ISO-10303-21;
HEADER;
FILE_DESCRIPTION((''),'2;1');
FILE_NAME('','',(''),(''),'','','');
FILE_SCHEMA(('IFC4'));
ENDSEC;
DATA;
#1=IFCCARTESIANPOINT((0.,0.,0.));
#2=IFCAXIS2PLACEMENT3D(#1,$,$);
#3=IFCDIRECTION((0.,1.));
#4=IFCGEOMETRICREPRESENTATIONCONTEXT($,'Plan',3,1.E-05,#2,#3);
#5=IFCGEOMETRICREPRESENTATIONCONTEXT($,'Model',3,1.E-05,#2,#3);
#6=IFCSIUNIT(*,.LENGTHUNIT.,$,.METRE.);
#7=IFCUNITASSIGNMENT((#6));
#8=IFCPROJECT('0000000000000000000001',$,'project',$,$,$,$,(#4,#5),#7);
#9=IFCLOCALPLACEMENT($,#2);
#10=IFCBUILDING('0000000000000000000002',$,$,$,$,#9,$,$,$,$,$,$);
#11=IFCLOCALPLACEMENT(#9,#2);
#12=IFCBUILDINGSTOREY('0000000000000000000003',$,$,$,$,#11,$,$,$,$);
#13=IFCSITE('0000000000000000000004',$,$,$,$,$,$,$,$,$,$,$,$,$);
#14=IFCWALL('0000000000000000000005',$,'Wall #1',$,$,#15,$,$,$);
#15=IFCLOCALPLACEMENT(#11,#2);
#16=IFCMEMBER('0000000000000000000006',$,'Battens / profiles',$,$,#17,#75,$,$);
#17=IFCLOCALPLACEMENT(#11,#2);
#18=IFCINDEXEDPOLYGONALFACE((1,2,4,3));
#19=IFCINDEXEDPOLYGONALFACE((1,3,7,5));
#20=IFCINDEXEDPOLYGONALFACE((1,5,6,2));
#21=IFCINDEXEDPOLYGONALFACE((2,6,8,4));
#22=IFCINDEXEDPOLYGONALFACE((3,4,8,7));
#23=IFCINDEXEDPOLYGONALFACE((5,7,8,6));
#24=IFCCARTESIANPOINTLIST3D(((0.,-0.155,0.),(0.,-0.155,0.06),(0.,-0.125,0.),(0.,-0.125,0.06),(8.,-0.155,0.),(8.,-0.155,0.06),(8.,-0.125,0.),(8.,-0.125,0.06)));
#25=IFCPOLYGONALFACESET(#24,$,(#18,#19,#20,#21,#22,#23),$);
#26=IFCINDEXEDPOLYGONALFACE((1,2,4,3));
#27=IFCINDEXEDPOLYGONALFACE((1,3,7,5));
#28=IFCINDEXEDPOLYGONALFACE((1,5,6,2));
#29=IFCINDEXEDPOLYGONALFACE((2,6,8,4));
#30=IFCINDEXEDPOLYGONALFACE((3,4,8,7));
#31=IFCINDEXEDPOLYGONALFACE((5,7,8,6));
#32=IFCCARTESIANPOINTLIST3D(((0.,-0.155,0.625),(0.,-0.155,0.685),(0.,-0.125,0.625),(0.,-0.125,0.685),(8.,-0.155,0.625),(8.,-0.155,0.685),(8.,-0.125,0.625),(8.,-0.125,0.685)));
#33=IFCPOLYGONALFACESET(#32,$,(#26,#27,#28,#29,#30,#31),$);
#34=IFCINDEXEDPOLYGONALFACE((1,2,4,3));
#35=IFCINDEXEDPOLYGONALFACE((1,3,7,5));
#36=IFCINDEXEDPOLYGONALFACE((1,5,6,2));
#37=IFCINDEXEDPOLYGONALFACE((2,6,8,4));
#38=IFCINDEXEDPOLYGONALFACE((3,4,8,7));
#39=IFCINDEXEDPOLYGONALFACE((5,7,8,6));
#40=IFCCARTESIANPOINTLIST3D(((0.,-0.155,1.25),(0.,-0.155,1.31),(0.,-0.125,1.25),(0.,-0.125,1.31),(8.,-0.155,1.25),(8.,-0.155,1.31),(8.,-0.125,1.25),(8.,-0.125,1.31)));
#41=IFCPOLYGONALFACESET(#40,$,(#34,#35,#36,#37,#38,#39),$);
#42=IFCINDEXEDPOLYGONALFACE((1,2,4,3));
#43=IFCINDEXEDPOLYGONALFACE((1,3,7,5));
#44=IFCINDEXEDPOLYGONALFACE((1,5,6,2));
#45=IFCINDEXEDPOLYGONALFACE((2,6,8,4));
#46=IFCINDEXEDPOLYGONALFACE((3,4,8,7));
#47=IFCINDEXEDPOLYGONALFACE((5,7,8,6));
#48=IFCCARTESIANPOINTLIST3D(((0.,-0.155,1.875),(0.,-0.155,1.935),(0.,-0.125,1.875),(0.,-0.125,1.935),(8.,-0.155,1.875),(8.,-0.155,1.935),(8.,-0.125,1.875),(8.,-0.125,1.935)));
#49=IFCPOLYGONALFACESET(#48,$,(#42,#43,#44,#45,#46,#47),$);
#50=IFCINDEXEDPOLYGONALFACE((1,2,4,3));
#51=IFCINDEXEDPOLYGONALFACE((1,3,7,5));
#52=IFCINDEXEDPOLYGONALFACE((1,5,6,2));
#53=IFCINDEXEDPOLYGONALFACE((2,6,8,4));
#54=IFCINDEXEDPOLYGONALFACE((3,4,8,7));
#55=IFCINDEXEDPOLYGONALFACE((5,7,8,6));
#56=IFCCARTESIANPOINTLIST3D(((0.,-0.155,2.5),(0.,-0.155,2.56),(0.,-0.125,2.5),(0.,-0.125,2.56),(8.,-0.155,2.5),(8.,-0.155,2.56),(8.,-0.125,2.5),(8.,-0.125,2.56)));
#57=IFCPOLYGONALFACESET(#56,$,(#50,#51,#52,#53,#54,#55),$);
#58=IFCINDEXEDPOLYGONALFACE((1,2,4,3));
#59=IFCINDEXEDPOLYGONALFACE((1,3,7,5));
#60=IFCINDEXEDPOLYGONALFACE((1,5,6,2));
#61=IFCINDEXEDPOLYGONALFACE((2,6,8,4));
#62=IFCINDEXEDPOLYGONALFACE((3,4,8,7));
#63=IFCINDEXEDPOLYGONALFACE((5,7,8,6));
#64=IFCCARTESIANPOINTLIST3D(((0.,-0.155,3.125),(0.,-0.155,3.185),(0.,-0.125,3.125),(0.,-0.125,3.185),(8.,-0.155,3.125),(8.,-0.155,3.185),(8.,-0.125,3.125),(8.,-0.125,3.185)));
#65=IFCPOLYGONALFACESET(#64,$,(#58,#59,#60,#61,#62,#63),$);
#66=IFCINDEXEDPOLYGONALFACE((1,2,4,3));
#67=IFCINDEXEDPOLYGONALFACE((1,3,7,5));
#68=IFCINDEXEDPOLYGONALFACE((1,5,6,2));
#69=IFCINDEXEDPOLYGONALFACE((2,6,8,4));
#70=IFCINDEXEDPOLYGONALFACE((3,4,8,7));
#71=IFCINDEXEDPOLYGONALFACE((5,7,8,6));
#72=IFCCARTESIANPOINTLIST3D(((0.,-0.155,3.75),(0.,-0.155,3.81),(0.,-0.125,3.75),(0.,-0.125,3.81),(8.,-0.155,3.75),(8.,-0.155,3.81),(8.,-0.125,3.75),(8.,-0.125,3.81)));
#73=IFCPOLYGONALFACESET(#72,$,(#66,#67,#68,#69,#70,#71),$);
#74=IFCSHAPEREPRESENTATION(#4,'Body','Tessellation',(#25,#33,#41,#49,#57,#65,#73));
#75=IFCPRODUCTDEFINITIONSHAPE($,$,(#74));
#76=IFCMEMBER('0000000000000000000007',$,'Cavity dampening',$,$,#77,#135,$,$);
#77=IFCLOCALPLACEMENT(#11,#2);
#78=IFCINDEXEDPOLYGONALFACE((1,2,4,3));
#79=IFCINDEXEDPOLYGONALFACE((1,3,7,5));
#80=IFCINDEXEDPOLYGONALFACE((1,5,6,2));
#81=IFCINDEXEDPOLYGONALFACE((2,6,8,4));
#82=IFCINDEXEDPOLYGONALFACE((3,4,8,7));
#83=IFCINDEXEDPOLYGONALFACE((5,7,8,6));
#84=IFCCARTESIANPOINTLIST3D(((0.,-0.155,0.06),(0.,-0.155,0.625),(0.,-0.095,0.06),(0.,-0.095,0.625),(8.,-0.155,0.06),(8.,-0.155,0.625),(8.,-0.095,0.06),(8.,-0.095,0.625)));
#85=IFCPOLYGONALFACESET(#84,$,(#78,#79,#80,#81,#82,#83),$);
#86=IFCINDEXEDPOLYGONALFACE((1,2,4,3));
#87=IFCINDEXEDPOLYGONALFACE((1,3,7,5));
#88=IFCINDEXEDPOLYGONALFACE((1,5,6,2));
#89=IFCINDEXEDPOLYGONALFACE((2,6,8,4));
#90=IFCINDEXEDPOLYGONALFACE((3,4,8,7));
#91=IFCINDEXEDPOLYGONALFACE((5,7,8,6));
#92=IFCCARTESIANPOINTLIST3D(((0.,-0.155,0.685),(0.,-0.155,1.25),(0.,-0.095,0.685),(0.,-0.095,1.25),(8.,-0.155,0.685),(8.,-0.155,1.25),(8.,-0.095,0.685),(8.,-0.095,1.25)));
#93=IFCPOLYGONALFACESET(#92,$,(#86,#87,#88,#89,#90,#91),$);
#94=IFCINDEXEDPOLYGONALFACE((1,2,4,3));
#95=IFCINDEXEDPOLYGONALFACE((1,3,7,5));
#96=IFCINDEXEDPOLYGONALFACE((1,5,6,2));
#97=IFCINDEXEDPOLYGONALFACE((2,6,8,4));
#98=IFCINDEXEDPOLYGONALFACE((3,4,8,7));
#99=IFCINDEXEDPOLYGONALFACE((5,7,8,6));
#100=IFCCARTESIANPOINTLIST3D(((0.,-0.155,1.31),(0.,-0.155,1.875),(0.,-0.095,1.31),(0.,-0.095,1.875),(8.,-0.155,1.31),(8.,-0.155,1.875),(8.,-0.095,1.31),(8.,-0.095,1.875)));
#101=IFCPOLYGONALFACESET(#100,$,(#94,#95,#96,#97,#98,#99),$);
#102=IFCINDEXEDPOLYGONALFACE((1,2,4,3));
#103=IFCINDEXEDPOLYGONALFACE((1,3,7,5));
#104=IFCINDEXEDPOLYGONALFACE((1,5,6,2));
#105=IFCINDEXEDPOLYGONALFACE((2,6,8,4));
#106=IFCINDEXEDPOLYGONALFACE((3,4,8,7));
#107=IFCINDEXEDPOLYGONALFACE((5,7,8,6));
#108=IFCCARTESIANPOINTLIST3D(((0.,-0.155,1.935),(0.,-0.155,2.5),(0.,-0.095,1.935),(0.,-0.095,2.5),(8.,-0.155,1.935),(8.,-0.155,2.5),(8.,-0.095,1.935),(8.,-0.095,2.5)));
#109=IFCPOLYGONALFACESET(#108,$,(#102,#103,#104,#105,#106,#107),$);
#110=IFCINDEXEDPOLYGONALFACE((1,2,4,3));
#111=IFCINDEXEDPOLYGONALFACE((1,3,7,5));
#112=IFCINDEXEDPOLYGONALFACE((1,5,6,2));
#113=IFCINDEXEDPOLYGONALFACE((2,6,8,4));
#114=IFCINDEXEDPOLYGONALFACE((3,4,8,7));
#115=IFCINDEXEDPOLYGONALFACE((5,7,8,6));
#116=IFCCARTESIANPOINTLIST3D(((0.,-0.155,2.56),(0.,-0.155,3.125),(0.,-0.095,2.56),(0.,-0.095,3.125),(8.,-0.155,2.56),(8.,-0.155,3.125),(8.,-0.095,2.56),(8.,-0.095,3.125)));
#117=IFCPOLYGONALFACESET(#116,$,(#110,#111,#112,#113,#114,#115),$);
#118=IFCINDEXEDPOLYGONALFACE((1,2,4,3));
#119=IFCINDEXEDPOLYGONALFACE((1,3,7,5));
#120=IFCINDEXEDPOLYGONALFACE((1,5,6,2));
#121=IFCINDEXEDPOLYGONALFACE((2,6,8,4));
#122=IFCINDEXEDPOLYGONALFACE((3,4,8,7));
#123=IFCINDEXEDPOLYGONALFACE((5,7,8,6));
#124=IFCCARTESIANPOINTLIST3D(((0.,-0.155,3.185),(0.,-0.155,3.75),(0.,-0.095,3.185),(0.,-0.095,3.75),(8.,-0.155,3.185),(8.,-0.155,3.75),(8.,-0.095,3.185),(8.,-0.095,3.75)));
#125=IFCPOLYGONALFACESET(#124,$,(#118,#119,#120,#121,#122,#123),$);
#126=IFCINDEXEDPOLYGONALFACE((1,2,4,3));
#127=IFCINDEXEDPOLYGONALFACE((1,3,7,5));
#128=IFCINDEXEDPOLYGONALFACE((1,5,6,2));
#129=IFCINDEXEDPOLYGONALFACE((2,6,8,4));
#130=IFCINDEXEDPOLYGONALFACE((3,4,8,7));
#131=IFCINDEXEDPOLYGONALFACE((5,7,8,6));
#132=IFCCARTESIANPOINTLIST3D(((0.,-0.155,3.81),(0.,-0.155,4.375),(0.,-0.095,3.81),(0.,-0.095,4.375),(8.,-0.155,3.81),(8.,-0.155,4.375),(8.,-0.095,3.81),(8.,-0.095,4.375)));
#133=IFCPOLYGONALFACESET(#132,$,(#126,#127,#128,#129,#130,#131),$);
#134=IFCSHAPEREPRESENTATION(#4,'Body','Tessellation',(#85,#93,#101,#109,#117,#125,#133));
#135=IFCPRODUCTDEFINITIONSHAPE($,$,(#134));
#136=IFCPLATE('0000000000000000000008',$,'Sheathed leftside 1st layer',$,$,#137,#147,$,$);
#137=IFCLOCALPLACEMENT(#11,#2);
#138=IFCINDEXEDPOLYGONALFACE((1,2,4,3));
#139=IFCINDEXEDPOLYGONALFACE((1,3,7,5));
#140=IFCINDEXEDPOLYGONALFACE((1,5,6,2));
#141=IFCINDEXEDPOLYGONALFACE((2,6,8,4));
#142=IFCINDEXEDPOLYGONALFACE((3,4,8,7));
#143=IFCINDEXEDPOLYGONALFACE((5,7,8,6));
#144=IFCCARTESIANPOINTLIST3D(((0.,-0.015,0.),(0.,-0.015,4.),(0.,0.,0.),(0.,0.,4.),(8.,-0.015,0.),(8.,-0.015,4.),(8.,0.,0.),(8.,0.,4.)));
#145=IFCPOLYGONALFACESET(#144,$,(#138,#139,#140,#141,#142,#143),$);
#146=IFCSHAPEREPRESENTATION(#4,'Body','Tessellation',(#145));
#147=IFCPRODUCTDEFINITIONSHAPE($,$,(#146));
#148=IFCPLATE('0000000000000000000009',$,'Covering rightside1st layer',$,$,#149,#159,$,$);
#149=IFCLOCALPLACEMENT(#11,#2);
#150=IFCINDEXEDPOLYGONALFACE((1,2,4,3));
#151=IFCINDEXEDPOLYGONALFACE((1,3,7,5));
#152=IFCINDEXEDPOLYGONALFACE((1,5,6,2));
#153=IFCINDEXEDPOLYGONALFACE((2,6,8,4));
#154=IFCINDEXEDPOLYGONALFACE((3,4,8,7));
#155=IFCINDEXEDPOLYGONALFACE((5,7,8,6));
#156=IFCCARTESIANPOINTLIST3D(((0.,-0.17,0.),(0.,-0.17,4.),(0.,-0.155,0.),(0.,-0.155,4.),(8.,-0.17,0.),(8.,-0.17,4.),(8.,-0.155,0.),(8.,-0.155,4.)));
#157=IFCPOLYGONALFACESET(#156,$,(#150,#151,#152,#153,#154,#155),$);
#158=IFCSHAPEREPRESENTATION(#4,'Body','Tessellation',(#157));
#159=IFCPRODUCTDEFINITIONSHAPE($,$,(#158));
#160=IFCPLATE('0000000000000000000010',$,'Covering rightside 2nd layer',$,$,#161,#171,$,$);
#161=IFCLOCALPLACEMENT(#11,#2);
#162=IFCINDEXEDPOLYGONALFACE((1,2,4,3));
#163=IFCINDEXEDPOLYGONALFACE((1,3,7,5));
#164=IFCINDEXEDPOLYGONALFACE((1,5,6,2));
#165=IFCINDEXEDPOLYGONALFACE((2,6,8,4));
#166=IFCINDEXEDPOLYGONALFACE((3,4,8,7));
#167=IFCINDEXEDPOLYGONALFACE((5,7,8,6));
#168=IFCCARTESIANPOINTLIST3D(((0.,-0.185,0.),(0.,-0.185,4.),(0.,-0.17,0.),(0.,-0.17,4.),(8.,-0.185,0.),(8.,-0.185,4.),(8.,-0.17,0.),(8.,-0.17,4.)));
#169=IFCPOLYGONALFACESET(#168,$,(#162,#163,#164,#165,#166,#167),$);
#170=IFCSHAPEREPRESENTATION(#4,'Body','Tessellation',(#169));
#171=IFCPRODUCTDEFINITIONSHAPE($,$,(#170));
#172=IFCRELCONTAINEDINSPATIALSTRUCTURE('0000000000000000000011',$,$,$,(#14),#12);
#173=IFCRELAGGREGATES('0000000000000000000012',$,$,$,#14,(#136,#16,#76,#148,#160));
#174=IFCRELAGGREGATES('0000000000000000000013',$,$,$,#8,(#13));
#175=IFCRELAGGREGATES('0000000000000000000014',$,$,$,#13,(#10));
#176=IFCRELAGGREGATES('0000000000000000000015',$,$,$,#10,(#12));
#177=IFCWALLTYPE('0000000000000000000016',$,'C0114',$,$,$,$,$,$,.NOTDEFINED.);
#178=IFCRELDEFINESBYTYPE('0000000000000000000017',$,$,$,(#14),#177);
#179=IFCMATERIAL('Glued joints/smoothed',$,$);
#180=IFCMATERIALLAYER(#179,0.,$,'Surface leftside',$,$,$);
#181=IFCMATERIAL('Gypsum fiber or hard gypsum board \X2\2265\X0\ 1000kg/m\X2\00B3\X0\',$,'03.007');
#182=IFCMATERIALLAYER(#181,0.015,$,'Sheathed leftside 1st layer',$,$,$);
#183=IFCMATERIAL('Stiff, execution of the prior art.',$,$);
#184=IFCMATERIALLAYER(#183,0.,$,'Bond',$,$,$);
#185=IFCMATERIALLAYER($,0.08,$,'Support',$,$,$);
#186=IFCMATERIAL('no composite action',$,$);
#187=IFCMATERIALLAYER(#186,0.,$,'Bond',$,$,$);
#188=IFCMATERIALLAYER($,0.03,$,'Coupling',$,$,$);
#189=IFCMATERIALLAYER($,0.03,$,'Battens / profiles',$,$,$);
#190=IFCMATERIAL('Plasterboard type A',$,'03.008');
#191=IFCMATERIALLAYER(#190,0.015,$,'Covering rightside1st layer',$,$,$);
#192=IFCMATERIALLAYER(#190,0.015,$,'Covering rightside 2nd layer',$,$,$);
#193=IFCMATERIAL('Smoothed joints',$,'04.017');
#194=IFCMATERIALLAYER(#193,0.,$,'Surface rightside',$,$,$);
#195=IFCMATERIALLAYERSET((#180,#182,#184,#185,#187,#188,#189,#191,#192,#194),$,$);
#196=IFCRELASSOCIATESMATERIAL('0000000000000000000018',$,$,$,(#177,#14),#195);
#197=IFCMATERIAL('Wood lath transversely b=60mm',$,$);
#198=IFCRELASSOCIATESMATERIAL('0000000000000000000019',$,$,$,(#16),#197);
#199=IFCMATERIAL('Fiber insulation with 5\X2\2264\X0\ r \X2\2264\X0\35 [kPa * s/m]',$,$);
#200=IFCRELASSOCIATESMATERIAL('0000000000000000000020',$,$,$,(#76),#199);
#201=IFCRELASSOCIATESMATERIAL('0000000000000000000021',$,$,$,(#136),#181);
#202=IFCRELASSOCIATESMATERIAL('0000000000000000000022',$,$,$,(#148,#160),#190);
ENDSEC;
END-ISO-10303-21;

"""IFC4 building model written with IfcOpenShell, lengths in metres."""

from ifc_helpers import new_model, si_unit, direction, frame, frame_2d, origin, origin_with_axes, place, context, project, spatial, rectangle, extrude, material, layer, layer_set, type_object, element, aggregate, save


model = new_model("IFC4")

# Units and contexts
plan_context = context("Plan", 3, precision=1e-05, world=origin(), true_north=direction((0.0, 1.0)))
model_context = context("Model", 3, precision=1e-05, world=origin(), true_north=direction((0.0, 1.0)))
ifc_project = project(units=[si_unit("LENGTHUNIT", "METRE")], contexts=[plan_context, model_context])

# Site, building, storey
site = spatial("IfcSite", under=ifc_project)
building_placement = place(None, origin())
building = spatial("IfcBuilding", under=site, at=building_placement)
storey_placement = place(building_placement, origin())
storey = spatial("IfcBuildingStorey", under=building, at=storey_placement)

# Wall, members, plates
ifc_material_1 = material(Name="Glued joints/smoothed")
ifc_layer_1 = layer(ifc_material_1, 0.0, Name="Surface leftside")
ifc_material_2 = material(Name="Gypsum fiber or hard gypsum board ≥ 1000kg/m³", Category="03.007")
ifc_layer_2 = layer(ifc_material_2, 0.015, Name="Sheathed leftside 1st layer")
ifc_material_3 = material(Name="Stiff, execution of the prior art.")
ifc_layer_3 = layer(ifc_material_3, 0.0, Name="Bond")
ifc_layer_4 = layer(None, 0.08, Name="Support")
ifc_material_4 = material(Name="no composite action")
ifc_layer_5 = layer(ifc_material_4, 0.0, Name="Bond")
ifc_layer_6 = layer(None, 0.03, Name="Coupling")
ifc_layer_7 = layer(None, 0.03, Name="Battens / profiles")
ifc_material_5 = material(Name="Plasterboard type A", Category="03.008")
ifc_layer_8 = layer(ifc_material_5, 0.015, Name="Covering rightside1st layer")
ifc_layer_9 = layer(ifc_material_5, 0.015, Name="Covering rightside 2nd layer")
ifc_material_6 = material(Name="Smoothed joints", Category="04.017")
ifc_layer_10 = layer(ifc_material_6, 0.0, Name="Surface rightside")
ifc_layer_set = layer_set([ifc_layer_1, ifc_layer_2, ifc_layer_3, ifc_layer_4, ifc_layer_5, ifc_layer_6, ifc_layer_7, ifc_layer_8, ifc_layer_9, ifc_layer_10])
wall_type = type_object("IfcWallType", Name="C0114", PredefinedType="NOTDEFINED", material=ifc_layer_set)
wall_placement = place(None, frame((0.0, 0.0, 0.0), z_axis=(0.0, -1.0, 0.0), x_axis=(1.0, 0.0, 0.0)))
wall = element("IfcWall", 1, at=wall_placement, inside=storey, type_object=wall_type, material=ifc_layer_set, Name="Wall #1")
ifc_material_7 = material(Name="Wood lath transversely b=60mm")
member_1_placement = place(wall_placement, origin())
member_1 = element("IfcMember", 2, at=member_1_placement, material=ifc_material_7, Name="Battens / profiles", context=plan_context, shape_type="SweptSolid", body=[
    extrude(rectangle(XDim=0.06, YDim=0.03, at=frame_2d((0.03, 0.015), x_axis=(1.0, 0.0))), frame((0.0, 0.0, 0.125), z_axis=(1.0, 0.0, 0.0), x_axis=(0.0, 1.0, 0.0)), (0.0, 0.0, 1.0), 8.0),
    extrude(rectangle(XDim=0.06, YDim=0.03, at=frame_2d((0.03, 0.015), x_axis=(1.0, 0.0))), frame((0.0, 0.625, 0.125), z_axis=(1.0, 0.0, 0.0), x_axis=(0.0, 1.0, 0.0)), (0.0, 0.0, 1.0), 8.0),
    extrude(rectangle(XDim=0.06, YDim=0.03, at=frame_2d((0.03, 0.015), x_axis=(1.0, 0.0))), frame((0.0, 1.25, 0.125), z_axis=(1.0, 0.0, 0.0), x_axis=(0.0, 1.0, 0.0)), (0.0, 0.0, 1.0), 8.0),
    extrude(rectangle(XDim=0.06, YDim=0.03, at=frame_2d((0.03, 0.015), x_axis=(1.0, 0.0))), frame((0.0, 1.875, 0.125), z_axis=(1.0, 0.0, 0.0), x_axis=(0.0, 1.0, 0.0)), (0.0, 0.0, 1.0), 8.0),
    extrude(rectangle(XDim=0.06, YDim=0.03, at=frame_2d((0.03, 0.015), x_axis=(1.0, 0.0))), frame((0.0, 2.5, 0.125), z_axis=(1.0, 0.0, 0.0), x_axis=(0.0, 1.0, 0.0)), (0.0, 0.0, 1.0), 8.0),
    extrude(rectangle(XDim=0.06, YDim=0.03, at=frame_2d((0.03, 0.015), x_axis=(1.0, 0.0))), frame((0.0, 3.125, 0.125), z_axis=(1.0, 0.0, 0.0), x_axis=(0.0, 1.0, 0.0)), (0.0, 0.0, 1.0), 8.0),
    extrude(rectangle(XDim=0.06, YDim=0.03, at=frame_2d((0.03, 0.015), x_axis=(1.0, 0.0))), frame((0.0, 3.75, 0.125), z_axis=(1.0, 0.0, 0.0), x_axis=(0.0, 1.0, 0.0)), (0.0, 0.0, 1.0), 8.0),
])
ifc_material_8 = material(Name="Fiber insulation with 5≤ r ≤35 [kPa * s/m]")
member_2_placement = place(wall_placement, origin())
member_2 = element("IfcMember", 3, at=member_2_placement, material=ifc_material_8, Name="Cavity dampening", context=plan_context, shape_type="SweptSolid", body=[
    extrude(rectangle(XDim=0.565, YDim=0.06, at=frame_2d((0.2825, 0.03), x_axis=(1.0, 0.0))), frame((0.0, 0.06, 0.095), z_axis=(1.0, 0.0, 0.0), x_axis=(0.0, 1.0, 0.0)), (0.0, 0.0, 1.0), 8.0),
    extrude(rectangle(XDim=0.565, YDim=0.06, at=frame_2d((0.2825, 0.03), x_axis=(1.0, 0.0))), frame((0.0, 0.685, 0.095), z_axis=(1.0, 0.0, 0.0), x_axis=(0.0, 1.0, 0.0)), (0.0, 0.0, 1.0), 8.0),
    extrude(rectangle(XDim=0.565, YDim=0.06, at=frame_2d((0.2825, 0.03), x_axis=(1.0, 0.0))), frame((0.0, 1.31, 0.095), z_axis=(1.0, 0.0, 0.0), x_axis=(0.0, 1.0, 0.0)), (0.0, 0.0, 1.0), 8.0),
    extrude(rectangle(XDim=0.565, YDim=0.06, at=frame_2d((0.2825, 0.03), x_axis=(1.0, 0.0))), frame((0.0, 1.935, 0.095), z_axis=(1.0, 0.0, 0.0), x_axis=(0.0, 1.0, 0.0)), (0.0, 0.0, 1.0), 8.0),
    extrude(rectangle(XDim=0.565, YDim=0.06, at=frame_2d((0.2825, 0.03), x_axis=(1.0, 0.0))), frame((0.0, 2.56, 0.095), z_axis=(1.0, 0.0, 0.0), x_axis=(0.0, 1.0, 0.0)), (0.0, 0.0, 1.0), 8.0),
    extrude(rectangle(XDim=0.565, YDim=0.06, at=frame_2d((0.2825, 0.03), x_axis=(1.0, 0.0))), frame((0.0, 3.185, 0.095), z_axis=(1.0, 0.0, 0.0), x_axis=(0.0, 1.0, 0.0)), (0.0, 0.0, 1.0), 8.0),
    extrude(rectangle(XDim=0.565, YDim=0.06, at=frame_2d((0.2825, 0.03), x_axis=(1.0, 0.0))), frame((0.0, 3.81, 0.095), z_axis=(1.0, 0.0, 0.0), x_axis=(0.0, 1.0, 0.0)), (0.0, 0.0, 1.0), 8.0),
])
plate_1_placement = place(wall_placement, origin())
plate_1 = element("IfcPlate", 4, at=plate_1_placement, material=ifc_material_2, Name="Sheathed leftside 1st layer", context=plan_context, shape_type="SweptSolid", body=[
    extrude(rectangle(XDim=8.0, YDim=4.0, at=frame_2d((4.0, 2.0), x_axis=(1.0, 0.0))), origin_with_axes(), (0.0, 0.0, 1.0), 0.015),
])
plate_2_placement = place(wall_placement, origin())
plate_2 = element("IfcPlate", 5, at=plate_2_placement, material=ifc_material_5, Name="Covering rightside1st layer", context=plan_context, shape_type="SweptSolid", body=[
    extrude(rectangle(XDim=8.0, YDim=4.0, at=frame_2d((4.0, 2.0), x_axis=(1.0, 0.0))), frame((0.0, 0.0, 0.155), z_axis=(0.0, 0.0, 1.0), x_axis=(1.0, 0.0, 0.0)), (0.0, 0.0, 1.0), 0.015),
])
plate_3_placement = place(wall_placement, origin())
plate_3 = element("IfcPlate", 6, at=plate_3_placement, material=ifc_material_5, Name="Covering rightside 2nd layer", context=plan_context, shape_type="SweptSolid", body=[
    extrude(rectangle(XDim=8.0, YDim=4.0, at=frame_2d((4.0, 2.0), x_axis=(1.0, 0.0))), frame((0.0, 0.0, 0.17), z_axis=(0.0, 0.0, 1.0), x_axis=(1.0, 0.0, 0.0)), (0.0, 0.0, 1.0), 0.015),
])
aggregate(wall, [plate_1, member_1, member_2, plate_2, plate_3])

save(model, "model.ifc")
